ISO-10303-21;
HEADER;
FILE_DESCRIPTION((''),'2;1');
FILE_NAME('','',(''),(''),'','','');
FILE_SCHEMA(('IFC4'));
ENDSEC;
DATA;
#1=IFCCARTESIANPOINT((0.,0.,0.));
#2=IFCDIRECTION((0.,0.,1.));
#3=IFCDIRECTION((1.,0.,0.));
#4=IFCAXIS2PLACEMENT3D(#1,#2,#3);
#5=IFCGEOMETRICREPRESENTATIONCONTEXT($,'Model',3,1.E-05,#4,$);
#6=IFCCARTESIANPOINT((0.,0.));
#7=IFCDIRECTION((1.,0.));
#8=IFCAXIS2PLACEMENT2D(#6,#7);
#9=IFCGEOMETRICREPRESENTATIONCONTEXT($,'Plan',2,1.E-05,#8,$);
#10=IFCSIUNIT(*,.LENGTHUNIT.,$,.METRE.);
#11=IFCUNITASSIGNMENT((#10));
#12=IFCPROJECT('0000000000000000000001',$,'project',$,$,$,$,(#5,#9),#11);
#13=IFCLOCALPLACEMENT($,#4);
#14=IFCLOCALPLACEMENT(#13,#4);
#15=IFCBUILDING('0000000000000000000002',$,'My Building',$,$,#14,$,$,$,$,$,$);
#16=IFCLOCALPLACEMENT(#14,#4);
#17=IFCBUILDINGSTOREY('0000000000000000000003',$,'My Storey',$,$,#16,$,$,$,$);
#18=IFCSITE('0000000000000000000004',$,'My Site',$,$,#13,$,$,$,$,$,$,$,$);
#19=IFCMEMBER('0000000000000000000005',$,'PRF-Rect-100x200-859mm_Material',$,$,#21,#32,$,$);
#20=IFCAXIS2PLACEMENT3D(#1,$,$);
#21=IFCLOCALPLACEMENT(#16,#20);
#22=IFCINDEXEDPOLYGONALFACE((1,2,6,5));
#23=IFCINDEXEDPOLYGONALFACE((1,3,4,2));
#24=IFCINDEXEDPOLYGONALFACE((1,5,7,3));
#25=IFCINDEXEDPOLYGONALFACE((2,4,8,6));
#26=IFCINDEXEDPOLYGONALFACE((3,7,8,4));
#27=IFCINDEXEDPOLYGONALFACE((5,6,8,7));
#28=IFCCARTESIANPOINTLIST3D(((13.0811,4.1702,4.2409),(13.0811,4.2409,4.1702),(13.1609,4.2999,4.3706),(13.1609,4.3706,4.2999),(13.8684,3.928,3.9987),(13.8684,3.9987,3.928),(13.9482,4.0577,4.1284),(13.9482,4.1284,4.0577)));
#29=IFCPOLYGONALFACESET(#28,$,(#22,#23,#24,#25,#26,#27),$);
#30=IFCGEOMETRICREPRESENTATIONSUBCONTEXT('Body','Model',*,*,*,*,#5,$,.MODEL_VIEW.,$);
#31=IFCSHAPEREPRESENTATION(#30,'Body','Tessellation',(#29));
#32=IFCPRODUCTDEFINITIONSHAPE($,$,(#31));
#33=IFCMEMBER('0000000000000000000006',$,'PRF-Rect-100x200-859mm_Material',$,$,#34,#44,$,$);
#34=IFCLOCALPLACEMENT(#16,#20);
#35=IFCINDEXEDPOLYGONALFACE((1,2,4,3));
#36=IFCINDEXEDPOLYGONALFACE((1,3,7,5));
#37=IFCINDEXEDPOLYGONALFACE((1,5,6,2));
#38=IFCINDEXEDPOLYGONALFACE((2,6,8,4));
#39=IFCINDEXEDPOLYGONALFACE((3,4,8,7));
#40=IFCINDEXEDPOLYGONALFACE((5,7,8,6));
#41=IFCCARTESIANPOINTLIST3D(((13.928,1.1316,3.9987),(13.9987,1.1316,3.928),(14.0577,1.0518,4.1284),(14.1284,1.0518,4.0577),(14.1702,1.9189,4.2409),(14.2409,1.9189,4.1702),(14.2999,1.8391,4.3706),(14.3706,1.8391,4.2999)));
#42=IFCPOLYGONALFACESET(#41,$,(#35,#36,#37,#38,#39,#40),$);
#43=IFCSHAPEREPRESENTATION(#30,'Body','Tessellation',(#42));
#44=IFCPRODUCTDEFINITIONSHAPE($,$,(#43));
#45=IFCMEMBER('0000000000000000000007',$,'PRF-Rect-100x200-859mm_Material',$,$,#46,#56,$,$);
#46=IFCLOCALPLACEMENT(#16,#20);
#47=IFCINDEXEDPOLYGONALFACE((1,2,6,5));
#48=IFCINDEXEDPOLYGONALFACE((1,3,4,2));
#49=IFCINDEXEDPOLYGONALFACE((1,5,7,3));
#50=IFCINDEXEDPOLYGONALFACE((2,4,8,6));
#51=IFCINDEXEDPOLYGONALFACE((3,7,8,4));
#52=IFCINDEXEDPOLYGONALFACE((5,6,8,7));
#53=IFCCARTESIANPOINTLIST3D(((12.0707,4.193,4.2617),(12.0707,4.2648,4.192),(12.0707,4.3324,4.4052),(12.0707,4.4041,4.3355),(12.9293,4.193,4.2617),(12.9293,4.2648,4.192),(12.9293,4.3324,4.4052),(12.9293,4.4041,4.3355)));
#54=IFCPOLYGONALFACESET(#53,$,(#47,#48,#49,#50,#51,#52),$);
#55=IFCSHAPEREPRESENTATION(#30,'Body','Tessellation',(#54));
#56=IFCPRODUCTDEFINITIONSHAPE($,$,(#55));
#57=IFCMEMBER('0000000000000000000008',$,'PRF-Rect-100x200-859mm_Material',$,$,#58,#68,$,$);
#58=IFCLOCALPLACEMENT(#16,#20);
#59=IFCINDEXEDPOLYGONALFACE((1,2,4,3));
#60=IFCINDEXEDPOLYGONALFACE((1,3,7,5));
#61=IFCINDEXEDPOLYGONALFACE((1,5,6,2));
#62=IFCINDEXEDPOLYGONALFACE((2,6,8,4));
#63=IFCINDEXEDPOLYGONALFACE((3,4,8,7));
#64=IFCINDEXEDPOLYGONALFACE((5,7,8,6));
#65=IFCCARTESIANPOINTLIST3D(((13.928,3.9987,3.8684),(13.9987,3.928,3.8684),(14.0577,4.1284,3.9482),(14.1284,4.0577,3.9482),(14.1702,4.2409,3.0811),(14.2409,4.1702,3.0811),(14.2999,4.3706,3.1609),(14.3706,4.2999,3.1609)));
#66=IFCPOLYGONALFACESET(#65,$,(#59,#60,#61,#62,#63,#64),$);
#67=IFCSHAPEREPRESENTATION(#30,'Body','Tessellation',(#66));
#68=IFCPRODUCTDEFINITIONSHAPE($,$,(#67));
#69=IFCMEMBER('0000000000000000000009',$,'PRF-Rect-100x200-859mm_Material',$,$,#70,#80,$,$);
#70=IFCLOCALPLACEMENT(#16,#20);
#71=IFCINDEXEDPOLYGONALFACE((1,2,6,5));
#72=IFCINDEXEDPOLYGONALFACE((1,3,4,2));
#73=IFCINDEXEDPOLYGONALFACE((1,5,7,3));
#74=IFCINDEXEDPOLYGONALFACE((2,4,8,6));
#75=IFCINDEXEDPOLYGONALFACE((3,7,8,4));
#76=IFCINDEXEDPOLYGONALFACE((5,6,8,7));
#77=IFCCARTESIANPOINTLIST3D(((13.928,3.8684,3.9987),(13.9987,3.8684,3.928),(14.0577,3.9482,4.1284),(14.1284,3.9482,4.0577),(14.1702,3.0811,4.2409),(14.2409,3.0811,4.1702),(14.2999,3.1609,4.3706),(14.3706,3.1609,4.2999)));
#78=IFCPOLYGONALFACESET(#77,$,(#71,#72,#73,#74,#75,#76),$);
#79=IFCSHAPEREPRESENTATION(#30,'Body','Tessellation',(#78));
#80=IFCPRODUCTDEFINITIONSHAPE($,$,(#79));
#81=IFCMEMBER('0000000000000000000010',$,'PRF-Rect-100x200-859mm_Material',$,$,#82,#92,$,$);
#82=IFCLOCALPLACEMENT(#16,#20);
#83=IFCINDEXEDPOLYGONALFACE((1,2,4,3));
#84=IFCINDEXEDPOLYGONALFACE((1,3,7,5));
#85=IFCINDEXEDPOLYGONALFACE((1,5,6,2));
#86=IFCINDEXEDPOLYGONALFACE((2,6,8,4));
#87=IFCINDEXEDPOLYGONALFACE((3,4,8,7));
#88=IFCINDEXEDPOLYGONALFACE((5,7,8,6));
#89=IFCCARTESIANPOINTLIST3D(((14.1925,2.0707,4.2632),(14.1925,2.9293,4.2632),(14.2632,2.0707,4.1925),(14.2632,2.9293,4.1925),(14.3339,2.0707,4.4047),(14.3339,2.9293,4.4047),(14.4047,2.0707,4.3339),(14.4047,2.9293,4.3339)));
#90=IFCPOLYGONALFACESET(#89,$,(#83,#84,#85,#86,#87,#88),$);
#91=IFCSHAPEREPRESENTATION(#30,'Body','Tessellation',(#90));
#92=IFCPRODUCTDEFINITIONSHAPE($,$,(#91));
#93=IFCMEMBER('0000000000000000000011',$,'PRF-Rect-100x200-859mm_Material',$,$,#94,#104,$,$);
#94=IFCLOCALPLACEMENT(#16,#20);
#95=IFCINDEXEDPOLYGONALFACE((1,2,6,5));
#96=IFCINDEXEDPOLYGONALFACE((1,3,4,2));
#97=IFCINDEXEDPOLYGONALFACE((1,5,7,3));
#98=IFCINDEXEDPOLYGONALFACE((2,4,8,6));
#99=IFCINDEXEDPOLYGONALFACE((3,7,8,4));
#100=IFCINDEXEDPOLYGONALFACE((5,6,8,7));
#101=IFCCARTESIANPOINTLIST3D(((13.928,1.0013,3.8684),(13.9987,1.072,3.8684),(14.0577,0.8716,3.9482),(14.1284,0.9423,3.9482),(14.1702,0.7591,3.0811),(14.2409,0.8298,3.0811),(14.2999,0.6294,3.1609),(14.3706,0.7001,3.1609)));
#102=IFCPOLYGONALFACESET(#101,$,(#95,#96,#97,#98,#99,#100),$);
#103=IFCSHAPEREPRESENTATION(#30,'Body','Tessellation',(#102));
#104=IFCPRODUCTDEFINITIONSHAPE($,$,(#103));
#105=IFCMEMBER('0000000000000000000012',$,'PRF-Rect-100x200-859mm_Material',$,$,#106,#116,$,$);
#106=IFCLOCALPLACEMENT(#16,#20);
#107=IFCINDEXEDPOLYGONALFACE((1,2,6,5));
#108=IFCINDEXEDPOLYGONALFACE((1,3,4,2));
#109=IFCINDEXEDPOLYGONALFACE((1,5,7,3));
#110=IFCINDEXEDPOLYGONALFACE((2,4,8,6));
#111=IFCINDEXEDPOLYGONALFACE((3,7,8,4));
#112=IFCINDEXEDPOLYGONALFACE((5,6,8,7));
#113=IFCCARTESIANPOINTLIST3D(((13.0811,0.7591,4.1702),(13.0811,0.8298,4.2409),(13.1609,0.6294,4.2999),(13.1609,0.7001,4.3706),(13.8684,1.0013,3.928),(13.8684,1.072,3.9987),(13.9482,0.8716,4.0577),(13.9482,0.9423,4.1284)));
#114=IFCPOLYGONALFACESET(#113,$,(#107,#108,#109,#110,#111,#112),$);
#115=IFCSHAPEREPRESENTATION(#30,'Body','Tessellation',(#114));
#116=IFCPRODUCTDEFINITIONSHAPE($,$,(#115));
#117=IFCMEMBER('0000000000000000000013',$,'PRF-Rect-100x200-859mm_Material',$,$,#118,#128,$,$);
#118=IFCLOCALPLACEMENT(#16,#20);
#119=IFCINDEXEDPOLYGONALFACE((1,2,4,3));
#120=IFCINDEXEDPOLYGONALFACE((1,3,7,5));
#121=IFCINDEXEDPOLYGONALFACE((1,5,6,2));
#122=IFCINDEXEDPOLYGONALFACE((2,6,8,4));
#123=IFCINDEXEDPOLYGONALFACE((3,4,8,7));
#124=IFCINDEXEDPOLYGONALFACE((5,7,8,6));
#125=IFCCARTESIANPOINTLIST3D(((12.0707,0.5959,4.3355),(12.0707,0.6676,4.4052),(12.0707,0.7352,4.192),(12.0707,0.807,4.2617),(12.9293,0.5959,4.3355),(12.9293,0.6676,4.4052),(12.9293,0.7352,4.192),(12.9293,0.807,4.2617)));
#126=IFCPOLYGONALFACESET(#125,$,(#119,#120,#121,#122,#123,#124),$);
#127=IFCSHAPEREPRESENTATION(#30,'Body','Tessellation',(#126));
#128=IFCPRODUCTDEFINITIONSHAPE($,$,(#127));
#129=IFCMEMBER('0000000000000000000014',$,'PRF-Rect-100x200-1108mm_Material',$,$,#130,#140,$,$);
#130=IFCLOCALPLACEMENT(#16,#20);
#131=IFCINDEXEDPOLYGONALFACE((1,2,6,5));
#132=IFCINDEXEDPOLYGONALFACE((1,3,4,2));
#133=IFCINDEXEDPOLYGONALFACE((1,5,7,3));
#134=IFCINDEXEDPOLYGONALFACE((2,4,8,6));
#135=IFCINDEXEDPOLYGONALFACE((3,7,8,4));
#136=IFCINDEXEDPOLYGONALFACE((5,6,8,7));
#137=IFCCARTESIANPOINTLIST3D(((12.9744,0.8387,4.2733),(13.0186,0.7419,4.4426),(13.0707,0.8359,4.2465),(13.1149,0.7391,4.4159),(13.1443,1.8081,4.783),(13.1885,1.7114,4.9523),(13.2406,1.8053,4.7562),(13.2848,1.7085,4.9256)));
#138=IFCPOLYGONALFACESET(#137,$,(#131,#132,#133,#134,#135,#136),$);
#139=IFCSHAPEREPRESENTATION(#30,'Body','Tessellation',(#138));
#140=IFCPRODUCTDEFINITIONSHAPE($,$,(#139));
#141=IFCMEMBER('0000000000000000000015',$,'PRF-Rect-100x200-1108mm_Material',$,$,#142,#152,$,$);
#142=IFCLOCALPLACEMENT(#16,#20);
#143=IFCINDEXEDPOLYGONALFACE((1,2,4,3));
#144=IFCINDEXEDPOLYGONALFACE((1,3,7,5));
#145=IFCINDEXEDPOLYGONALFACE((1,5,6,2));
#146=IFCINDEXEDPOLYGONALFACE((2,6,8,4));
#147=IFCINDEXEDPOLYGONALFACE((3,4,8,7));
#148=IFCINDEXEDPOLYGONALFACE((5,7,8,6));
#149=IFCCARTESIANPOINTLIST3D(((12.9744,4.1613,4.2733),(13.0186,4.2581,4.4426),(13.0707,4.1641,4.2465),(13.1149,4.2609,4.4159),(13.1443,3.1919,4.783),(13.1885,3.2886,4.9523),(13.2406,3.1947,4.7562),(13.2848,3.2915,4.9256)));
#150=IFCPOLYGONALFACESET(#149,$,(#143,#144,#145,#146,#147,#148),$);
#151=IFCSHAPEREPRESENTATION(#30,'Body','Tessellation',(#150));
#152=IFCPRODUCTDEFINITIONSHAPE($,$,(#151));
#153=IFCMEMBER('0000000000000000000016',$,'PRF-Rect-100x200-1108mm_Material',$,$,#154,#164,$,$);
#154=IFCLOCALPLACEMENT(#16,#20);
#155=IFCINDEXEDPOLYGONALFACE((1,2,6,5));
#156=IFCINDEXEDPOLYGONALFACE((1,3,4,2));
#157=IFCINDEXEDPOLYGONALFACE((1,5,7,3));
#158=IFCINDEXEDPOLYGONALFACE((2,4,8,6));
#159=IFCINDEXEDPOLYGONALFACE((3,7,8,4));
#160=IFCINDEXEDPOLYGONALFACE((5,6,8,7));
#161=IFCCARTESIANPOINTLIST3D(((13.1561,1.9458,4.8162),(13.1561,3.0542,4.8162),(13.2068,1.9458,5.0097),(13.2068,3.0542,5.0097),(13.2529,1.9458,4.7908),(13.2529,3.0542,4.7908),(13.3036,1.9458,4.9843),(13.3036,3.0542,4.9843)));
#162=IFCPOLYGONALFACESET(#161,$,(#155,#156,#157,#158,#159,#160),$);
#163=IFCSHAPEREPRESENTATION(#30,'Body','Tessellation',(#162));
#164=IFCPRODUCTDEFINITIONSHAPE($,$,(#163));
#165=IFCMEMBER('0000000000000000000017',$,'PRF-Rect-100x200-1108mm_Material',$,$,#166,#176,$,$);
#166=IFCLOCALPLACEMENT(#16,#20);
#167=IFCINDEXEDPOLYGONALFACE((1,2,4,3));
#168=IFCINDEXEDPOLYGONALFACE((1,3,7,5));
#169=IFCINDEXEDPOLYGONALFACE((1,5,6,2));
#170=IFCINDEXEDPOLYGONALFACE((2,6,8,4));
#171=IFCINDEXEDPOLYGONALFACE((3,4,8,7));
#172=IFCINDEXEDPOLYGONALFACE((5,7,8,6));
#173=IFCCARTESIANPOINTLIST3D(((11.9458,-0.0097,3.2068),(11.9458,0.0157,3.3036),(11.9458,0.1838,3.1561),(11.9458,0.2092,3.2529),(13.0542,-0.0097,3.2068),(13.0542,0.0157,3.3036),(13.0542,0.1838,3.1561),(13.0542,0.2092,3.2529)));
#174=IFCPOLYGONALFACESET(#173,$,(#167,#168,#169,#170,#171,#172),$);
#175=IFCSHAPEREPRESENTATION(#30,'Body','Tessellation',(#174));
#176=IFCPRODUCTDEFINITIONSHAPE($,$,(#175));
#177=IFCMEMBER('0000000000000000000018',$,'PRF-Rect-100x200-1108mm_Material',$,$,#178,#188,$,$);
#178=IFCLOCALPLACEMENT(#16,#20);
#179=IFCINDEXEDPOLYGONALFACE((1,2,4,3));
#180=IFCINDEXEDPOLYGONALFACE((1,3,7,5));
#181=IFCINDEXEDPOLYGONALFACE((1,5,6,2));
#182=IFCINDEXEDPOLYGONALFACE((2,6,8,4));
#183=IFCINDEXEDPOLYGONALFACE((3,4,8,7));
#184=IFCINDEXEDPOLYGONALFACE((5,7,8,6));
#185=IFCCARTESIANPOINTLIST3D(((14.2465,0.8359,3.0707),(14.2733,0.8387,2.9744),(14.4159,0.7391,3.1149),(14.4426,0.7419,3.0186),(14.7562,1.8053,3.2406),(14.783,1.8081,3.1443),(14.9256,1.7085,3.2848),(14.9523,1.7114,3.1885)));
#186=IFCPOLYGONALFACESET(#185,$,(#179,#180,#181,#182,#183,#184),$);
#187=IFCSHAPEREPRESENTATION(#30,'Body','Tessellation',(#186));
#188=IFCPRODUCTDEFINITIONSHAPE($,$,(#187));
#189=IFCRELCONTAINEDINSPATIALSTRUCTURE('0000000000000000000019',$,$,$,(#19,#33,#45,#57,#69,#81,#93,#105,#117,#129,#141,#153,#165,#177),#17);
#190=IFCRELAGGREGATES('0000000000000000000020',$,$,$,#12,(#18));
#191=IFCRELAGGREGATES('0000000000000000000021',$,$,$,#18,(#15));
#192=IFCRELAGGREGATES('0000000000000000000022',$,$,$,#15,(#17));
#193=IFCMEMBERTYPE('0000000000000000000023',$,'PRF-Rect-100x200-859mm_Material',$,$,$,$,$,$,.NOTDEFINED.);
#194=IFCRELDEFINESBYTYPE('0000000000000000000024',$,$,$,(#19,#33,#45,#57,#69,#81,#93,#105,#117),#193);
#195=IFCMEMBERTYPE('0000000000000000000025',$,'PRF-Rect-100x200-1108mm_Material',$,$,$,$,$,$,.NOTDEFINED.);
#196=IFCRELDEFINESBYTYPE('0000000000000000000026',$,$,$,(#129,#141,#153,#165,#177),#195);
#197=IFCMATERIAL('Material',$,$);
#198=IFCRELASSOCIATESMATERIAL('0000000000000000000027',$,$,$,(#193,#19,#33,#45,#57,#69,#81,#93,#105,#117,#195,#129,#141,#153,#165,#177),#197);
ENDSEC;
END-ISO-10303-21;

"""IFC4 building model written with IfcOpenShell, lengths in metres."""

from ifc_helpers import new_model, si_unit, frame, origin, origin_with_axes, origin_2d_with_axis, place, context, subcontext, project, spatial, rectangle, extrude, material, material_profile, profile_set, profile_usage, type_object, element, save


model = new_model("IFC4")

# Units and contexts
model_context = context("Model", 3, precision=1e-05, world=origin_with_axes())
plan_context = context("Plan", 2, precision=1e-05, world=origin_2d_with_axis())
body_context = subcontext(model_context, "Body", "Model", "MODEL_VIEW")
ifc_project = project(units=[si_unit("LENGTHUNIT", "METRE")], contexts=[model_context, plan_context])

# Site, building, storey
site_placement = place(None, origin_with_axes())
site = spatial("IfcSite", under=ifc_project, at=site_placement, Name="My Site")
building_placement = place(site_placement, origin_with_axes())
building = spatial("IfcBuilding", under=site, at=building_placement, Name="My Building")
storey_placement = place(building_placement, origin_with_axes())
storey = spatial("IfcBuildingStorey", under=building, at=storey_placement, Name="My Storey")

# Members
ifc_material = material(Name="Material")
ifc_material_profile_1 = material_profile(ifc_material, rectangle(XDim=0.1, YDim=0.2))
ifc_profile_set_1 = profile_set([ifc_material_profile_1], Name="PRF-Rect-100x200-859mm_Material")
ifc_profile_usage_1 = profile_usage(ifc_profile_set_1, cardinal=5)
member_type_1 = type_object("IfcMemberType", Name="PRF-Rect-100x200-859mm_Material", PredefinedType="NOTDEFINED", material=ifc_profile_set_1)
member_1_placement = place(storey_placement, frame((13.121, 4.2704, 4.2704), z_axis=(0.916994, -0.282066, -0.282066), x_axis=(0.0, 0.707107, -0.707107)))
element("IfcMember", 1, at=member_1_placement, inside=storey, type_object=member_type_1, material=ifc_profile_usage_1, Name="PRF-Rect-100x200-859mm_Material", context=body_context, shape_type="SweptSolid", body=[
    extrude(rectangle(XDim=0.1, YDim=0.2), origin(), (0.0, 0.0, 1.0), 0.8586),
])
ifc_profile_usage_2 = profile_usage(ifc_profile_set_1, cardinal=5)
member_2_placement = place(storey_placement, frame((14.2704, 1.879, 4.2704), z_axis=(-0.282066, -0.916993, -0.282066), x_axis=(0.707107, 0.0, -0.707107)))
element("IfcMember", 2, at=member_2_placement, inside=storey, type_object=member_type_1, material=ifc_profile_usage_2, Name="PRF-Rect-100x200-859mm_Material", context=body_context, shape_type="SweptSolid", body=[
    extrude(rectangle(XDim=0.1, YDim=0.2), origin(), (0.0, 0.0, 1.0), 0.8586),
])
ifc_profile_usage_3 = profile_usage(ifc_profile_set_1, cardinal=5)
member_3_placement = place(storey_placement, frame((12.0707, 4.2986, 4.2986), z_axis=(1.0, 0.0, 0.0), x_axis=(0.0, 0.717183, -0.696885)))
element("IfcMember", 3, at=member_3_placement, inside=storey, type_object=member_type_1, material=ifc_profile_usage_3, Name="PRF-Rect-100x200-859mm_Material", context=body_context, shape_type="SweptSolid", body=[
    extrude(rectangle(XDim=0.1, YDim=0.2), origin(), (0.0, 0.0, 1.0), 0.8586),
])
ifc_profile_usage_4 = profile_usage(ifc_profile_set_1, cardinal=5)
member_4_placement = place(storey_placement, frame((14.0282, 4.0282, 3.9083), z_axis=(0.282066, 0.282066, -0.916994), x_axis=(-0.707107, 0.707107, 0.0)))
element("IfcMember", 4, at=member_4_placement, inside=storey, type_object=member_type_1, material=ifc_profile_usage_4, Name="PRF-Rect-100x200-859mm_Material", context=body_context, shape_type="SweptSolid", body=[
    extrude(rectangle(XDim=0.1, YDim=0.2), origin(), (0.0, 0.0, 1.0), 0.8586),
])
ifc_profile_usage_5 = profile_usage(ifc_profile_set_1, cardinal=5)
member_5_placement = place(storey_placement, frame((14.0282, 3.9083, 4.0282), z_axis=(0.282066, -0.916994, 0.282066), x_axis=(0.707107, 0.0, -0.707107)))
element("IfcMember", 5, at=member_5_placement, inside=storey, type_object=member_type_1, material=ifc_profile_usage_5, Name="PRF-Rect-100x200-859mm_Material", context=body_context, shape_type="SweptSolid", body=[
    extrude(rectangle(XDim=0.1, YDim=0.2), origin(), (0.0, 0.0, 1.0), 0.8586),
])
ifc_profile_usage_6 = profile_usage(ifc_profile_set_1, cardinal=5)
member_6_placement = place(storey_placement, frame((14.2986, 2.9293, 4.2986), z_axis=(0.0, -1.0, 0.0), x_axis=(0.707107, 0.0, -0.707107)))
element("IfcMember", 6, at=member_6_placement, inside=storey, type_object=member_type_1, material=ifc_profile_usage_6, Name="PRF-Rect-100x200-859mm_Material", context=body_context, shape_type="SweptSolid", body=[
    extrude(rectangle(XDim=0.1, YDim=0.2), origin(), (0.0, 0.0, 1.0), 0.8586),
])
ifc_profile_usage_7 = profile_usage(ifc_profile_set_1, cardinal=5)
member_7_placement = place(storey_placement, frame((14.0282, 0.9718, 3.9083), z_axis=(0.282066, -0.282066, -0.916994), x_axis=(0.707107, 0.707107, 0.0)))
element("IfcMember", 7, at=member_7_placement, inside=storey, type_object=member_type_1, material=ifc_profile_usage_7, Name="PRF-Rect-100x200-859mm_Material", context=body_context, shape_type="SweptSolid", body=[
    extrude(rectangle(XDim=0.1, YDim=0.2), origin(), (0.0, 0.0, 1.0), 0.8586),
])
ifc_profile_usage_8 = profile_usage(ifc_profile_set_1, cardinal=5)
member_8_placement = place(storey_placement, frame((13.9083, 0.9718, 4.0282), z_axis=(-0.916994, -0.282066, 0.282066), x_axis=(0.0, -0.707107, -0.707107)))
element("IfcMember", 8, at=member_8_placement, inside=storey, type_object=member_type_1, material=ifc_profile_usage_8, Name="PRF-Rect-100x200-859mm_Material", context=body_context, shape_type="SweptSolid", body=[
    extrude(rectangle(XDim=0.1, YDim=0.2), origin(), (0.0, 0.0, 1.0), 0.8586),
])
ifc_profile_usage_9 = profile_usage(ifc_profile_set_1, cardinal=5)
member_9_placement = place(storey_placement, frame((12.9293, 0.7014, 4.2986), z_axis=(-1.0, 0.0, 0.0), x_axis=(0.0, -0.717183, -0.696885)))
element("IfcMember", 9, at=member_9_placement, inside=storey, type_object=member_type_1, material=ifc_profile_usage_9, Name="PRF-Rect-100x200-859mm_Material", context=body_context, shape_type="SweptSolid", body=[
    extrude(rectangle(XDim=0.1, YDim=0.2), origin(), (0.0, 0.0, 1.0), 0.8586),
])
ifc_material_profile_2 = material_profile(ifc_material, rectangle(XDim=0.1, YDim=0.2))
ifc_profile_set_2 = profile_set([ifc_material_profile_2], Name="PRF-Rect-100x200-1108mm_Material")
ifc_profile_usage_10 = profile_usage(ifc_profile_set_2, cardinal=5)
member_type_2 = type_object("IfcMemberType", Name="PRF-Rect-100x200-1108mm_Material", PredefinedType="NOTDEFINED", material=ifc_profile_set_2)
member_10_placement = place(storey_placement, frame((13.2145, 1.7583, 4.8543), z_axis=(-0.153283, -0.874668, -0.459849), x_axis=(0.963147, -0.028153, -0.2675)))
element("IfcMember", 10, at=member_10_placement, inside=storey, type_object=member_type_2, material=ifc_profile_usage_10, Name="PRF-Rect-100x200-1108mm_Material", context=body_context, shape_type="SweptSolid", body=[
    extrude(rectangle(XDim=0.1, YDim=0.2), origin(), (0.0, 0.0, 1.0), 1.1084),
])
ifc_profile_usage_11 = profile_usage(ifc_profile_set_2, cardinal=5)
member_11_placement = place(storey_placement, frame((13.0446, 4.2111, 4.3446), z_axis=(0.153283, -0.874668, 0.459849), x_axis=(0.963147, 0.028153, -0.2675)))
element("IfcMember", 11, at=member_11_placement, inside=storey, type_object=member_type_2, material=ifc_profile_usage_11, Name="PRF-Rect-100x200-1108mm_Material", context=body_context, shape_type="SweptSolid", body=[
    extrude(rectangle(XDim=0.1, YDim=0.2), origin(), (0.0, 0.0, 1.0), 1.1084),
])
ifc_profile_usage_12 = profile_usage(ifc_profile_set_2, cardinal=5)
member_12_placement = place(storey_placement, frame((13.2298, 3.0542, 4.9002), z_axis=(0.0, -1.0, 0.0), x_axis=(0.967317, 0.0, -0.253569)))
element("IfcMember", 12, at=member_12_placement, inside=storey, type_object=member_type_2, material=ifc_profile_usage_12, Name="PRF-Rect-100x200-1108mm_Material", context=body_context, shape_type="SweptSolid", body=[
    extrude(rectangle(XDim=0.1, YDim=0.2), origin(), (0.0, 0.0, 1.0), 1.1084),
])
ifc_profile_usage_13 = profile_usage(ifc_profile_set_2, cardinal=5)
member_13_placement = place(storey_placement, frame((13.0542, 0.0998, 3.2298), z_axis=(-1.0, 0.0, 0.0), x_axis=(0.0, -0.253569, -0.967317)))
element("IfcMember", 13, at=member_13_placement, inside=storey, type_object=member_type_2, material=ifc_profile_usage_13, Name="PRF-Rect-100x200-1108mm_Material", context=body_context, shape_type="SweptSolid", body=[
    extrude(rectangle(XDim=0.1, YDim=0.2), origin(), (0.0, 0.0, 1.0), 1.1084),
])
ifc_profile_usage_14 = profile_usage(ifc_profile_set_2, cardinal=5)
member_14_placement = place(storey_placement, frame((14.8543, 1.7583, 3.2145), z_axis=(-0.459849, -0.874667, -0.153283), x_axis=(0.2675, 0.028153, -0.963147)))
element("IfcMember", 14, at=member_14_placement, inside=storey, type_object=member_type_2, material=ifc_profile_usage_14, Name="PRF-Rect-100x200-1108mm_Material", context=body_context, shape_type="SweptSolid", body=[
    extrude(rectangle(XDim=0.1, YDim=0.2), origin(), (0.0, 0.0, 1.0), 1.1084),
])

save(model, "model.ifc")
